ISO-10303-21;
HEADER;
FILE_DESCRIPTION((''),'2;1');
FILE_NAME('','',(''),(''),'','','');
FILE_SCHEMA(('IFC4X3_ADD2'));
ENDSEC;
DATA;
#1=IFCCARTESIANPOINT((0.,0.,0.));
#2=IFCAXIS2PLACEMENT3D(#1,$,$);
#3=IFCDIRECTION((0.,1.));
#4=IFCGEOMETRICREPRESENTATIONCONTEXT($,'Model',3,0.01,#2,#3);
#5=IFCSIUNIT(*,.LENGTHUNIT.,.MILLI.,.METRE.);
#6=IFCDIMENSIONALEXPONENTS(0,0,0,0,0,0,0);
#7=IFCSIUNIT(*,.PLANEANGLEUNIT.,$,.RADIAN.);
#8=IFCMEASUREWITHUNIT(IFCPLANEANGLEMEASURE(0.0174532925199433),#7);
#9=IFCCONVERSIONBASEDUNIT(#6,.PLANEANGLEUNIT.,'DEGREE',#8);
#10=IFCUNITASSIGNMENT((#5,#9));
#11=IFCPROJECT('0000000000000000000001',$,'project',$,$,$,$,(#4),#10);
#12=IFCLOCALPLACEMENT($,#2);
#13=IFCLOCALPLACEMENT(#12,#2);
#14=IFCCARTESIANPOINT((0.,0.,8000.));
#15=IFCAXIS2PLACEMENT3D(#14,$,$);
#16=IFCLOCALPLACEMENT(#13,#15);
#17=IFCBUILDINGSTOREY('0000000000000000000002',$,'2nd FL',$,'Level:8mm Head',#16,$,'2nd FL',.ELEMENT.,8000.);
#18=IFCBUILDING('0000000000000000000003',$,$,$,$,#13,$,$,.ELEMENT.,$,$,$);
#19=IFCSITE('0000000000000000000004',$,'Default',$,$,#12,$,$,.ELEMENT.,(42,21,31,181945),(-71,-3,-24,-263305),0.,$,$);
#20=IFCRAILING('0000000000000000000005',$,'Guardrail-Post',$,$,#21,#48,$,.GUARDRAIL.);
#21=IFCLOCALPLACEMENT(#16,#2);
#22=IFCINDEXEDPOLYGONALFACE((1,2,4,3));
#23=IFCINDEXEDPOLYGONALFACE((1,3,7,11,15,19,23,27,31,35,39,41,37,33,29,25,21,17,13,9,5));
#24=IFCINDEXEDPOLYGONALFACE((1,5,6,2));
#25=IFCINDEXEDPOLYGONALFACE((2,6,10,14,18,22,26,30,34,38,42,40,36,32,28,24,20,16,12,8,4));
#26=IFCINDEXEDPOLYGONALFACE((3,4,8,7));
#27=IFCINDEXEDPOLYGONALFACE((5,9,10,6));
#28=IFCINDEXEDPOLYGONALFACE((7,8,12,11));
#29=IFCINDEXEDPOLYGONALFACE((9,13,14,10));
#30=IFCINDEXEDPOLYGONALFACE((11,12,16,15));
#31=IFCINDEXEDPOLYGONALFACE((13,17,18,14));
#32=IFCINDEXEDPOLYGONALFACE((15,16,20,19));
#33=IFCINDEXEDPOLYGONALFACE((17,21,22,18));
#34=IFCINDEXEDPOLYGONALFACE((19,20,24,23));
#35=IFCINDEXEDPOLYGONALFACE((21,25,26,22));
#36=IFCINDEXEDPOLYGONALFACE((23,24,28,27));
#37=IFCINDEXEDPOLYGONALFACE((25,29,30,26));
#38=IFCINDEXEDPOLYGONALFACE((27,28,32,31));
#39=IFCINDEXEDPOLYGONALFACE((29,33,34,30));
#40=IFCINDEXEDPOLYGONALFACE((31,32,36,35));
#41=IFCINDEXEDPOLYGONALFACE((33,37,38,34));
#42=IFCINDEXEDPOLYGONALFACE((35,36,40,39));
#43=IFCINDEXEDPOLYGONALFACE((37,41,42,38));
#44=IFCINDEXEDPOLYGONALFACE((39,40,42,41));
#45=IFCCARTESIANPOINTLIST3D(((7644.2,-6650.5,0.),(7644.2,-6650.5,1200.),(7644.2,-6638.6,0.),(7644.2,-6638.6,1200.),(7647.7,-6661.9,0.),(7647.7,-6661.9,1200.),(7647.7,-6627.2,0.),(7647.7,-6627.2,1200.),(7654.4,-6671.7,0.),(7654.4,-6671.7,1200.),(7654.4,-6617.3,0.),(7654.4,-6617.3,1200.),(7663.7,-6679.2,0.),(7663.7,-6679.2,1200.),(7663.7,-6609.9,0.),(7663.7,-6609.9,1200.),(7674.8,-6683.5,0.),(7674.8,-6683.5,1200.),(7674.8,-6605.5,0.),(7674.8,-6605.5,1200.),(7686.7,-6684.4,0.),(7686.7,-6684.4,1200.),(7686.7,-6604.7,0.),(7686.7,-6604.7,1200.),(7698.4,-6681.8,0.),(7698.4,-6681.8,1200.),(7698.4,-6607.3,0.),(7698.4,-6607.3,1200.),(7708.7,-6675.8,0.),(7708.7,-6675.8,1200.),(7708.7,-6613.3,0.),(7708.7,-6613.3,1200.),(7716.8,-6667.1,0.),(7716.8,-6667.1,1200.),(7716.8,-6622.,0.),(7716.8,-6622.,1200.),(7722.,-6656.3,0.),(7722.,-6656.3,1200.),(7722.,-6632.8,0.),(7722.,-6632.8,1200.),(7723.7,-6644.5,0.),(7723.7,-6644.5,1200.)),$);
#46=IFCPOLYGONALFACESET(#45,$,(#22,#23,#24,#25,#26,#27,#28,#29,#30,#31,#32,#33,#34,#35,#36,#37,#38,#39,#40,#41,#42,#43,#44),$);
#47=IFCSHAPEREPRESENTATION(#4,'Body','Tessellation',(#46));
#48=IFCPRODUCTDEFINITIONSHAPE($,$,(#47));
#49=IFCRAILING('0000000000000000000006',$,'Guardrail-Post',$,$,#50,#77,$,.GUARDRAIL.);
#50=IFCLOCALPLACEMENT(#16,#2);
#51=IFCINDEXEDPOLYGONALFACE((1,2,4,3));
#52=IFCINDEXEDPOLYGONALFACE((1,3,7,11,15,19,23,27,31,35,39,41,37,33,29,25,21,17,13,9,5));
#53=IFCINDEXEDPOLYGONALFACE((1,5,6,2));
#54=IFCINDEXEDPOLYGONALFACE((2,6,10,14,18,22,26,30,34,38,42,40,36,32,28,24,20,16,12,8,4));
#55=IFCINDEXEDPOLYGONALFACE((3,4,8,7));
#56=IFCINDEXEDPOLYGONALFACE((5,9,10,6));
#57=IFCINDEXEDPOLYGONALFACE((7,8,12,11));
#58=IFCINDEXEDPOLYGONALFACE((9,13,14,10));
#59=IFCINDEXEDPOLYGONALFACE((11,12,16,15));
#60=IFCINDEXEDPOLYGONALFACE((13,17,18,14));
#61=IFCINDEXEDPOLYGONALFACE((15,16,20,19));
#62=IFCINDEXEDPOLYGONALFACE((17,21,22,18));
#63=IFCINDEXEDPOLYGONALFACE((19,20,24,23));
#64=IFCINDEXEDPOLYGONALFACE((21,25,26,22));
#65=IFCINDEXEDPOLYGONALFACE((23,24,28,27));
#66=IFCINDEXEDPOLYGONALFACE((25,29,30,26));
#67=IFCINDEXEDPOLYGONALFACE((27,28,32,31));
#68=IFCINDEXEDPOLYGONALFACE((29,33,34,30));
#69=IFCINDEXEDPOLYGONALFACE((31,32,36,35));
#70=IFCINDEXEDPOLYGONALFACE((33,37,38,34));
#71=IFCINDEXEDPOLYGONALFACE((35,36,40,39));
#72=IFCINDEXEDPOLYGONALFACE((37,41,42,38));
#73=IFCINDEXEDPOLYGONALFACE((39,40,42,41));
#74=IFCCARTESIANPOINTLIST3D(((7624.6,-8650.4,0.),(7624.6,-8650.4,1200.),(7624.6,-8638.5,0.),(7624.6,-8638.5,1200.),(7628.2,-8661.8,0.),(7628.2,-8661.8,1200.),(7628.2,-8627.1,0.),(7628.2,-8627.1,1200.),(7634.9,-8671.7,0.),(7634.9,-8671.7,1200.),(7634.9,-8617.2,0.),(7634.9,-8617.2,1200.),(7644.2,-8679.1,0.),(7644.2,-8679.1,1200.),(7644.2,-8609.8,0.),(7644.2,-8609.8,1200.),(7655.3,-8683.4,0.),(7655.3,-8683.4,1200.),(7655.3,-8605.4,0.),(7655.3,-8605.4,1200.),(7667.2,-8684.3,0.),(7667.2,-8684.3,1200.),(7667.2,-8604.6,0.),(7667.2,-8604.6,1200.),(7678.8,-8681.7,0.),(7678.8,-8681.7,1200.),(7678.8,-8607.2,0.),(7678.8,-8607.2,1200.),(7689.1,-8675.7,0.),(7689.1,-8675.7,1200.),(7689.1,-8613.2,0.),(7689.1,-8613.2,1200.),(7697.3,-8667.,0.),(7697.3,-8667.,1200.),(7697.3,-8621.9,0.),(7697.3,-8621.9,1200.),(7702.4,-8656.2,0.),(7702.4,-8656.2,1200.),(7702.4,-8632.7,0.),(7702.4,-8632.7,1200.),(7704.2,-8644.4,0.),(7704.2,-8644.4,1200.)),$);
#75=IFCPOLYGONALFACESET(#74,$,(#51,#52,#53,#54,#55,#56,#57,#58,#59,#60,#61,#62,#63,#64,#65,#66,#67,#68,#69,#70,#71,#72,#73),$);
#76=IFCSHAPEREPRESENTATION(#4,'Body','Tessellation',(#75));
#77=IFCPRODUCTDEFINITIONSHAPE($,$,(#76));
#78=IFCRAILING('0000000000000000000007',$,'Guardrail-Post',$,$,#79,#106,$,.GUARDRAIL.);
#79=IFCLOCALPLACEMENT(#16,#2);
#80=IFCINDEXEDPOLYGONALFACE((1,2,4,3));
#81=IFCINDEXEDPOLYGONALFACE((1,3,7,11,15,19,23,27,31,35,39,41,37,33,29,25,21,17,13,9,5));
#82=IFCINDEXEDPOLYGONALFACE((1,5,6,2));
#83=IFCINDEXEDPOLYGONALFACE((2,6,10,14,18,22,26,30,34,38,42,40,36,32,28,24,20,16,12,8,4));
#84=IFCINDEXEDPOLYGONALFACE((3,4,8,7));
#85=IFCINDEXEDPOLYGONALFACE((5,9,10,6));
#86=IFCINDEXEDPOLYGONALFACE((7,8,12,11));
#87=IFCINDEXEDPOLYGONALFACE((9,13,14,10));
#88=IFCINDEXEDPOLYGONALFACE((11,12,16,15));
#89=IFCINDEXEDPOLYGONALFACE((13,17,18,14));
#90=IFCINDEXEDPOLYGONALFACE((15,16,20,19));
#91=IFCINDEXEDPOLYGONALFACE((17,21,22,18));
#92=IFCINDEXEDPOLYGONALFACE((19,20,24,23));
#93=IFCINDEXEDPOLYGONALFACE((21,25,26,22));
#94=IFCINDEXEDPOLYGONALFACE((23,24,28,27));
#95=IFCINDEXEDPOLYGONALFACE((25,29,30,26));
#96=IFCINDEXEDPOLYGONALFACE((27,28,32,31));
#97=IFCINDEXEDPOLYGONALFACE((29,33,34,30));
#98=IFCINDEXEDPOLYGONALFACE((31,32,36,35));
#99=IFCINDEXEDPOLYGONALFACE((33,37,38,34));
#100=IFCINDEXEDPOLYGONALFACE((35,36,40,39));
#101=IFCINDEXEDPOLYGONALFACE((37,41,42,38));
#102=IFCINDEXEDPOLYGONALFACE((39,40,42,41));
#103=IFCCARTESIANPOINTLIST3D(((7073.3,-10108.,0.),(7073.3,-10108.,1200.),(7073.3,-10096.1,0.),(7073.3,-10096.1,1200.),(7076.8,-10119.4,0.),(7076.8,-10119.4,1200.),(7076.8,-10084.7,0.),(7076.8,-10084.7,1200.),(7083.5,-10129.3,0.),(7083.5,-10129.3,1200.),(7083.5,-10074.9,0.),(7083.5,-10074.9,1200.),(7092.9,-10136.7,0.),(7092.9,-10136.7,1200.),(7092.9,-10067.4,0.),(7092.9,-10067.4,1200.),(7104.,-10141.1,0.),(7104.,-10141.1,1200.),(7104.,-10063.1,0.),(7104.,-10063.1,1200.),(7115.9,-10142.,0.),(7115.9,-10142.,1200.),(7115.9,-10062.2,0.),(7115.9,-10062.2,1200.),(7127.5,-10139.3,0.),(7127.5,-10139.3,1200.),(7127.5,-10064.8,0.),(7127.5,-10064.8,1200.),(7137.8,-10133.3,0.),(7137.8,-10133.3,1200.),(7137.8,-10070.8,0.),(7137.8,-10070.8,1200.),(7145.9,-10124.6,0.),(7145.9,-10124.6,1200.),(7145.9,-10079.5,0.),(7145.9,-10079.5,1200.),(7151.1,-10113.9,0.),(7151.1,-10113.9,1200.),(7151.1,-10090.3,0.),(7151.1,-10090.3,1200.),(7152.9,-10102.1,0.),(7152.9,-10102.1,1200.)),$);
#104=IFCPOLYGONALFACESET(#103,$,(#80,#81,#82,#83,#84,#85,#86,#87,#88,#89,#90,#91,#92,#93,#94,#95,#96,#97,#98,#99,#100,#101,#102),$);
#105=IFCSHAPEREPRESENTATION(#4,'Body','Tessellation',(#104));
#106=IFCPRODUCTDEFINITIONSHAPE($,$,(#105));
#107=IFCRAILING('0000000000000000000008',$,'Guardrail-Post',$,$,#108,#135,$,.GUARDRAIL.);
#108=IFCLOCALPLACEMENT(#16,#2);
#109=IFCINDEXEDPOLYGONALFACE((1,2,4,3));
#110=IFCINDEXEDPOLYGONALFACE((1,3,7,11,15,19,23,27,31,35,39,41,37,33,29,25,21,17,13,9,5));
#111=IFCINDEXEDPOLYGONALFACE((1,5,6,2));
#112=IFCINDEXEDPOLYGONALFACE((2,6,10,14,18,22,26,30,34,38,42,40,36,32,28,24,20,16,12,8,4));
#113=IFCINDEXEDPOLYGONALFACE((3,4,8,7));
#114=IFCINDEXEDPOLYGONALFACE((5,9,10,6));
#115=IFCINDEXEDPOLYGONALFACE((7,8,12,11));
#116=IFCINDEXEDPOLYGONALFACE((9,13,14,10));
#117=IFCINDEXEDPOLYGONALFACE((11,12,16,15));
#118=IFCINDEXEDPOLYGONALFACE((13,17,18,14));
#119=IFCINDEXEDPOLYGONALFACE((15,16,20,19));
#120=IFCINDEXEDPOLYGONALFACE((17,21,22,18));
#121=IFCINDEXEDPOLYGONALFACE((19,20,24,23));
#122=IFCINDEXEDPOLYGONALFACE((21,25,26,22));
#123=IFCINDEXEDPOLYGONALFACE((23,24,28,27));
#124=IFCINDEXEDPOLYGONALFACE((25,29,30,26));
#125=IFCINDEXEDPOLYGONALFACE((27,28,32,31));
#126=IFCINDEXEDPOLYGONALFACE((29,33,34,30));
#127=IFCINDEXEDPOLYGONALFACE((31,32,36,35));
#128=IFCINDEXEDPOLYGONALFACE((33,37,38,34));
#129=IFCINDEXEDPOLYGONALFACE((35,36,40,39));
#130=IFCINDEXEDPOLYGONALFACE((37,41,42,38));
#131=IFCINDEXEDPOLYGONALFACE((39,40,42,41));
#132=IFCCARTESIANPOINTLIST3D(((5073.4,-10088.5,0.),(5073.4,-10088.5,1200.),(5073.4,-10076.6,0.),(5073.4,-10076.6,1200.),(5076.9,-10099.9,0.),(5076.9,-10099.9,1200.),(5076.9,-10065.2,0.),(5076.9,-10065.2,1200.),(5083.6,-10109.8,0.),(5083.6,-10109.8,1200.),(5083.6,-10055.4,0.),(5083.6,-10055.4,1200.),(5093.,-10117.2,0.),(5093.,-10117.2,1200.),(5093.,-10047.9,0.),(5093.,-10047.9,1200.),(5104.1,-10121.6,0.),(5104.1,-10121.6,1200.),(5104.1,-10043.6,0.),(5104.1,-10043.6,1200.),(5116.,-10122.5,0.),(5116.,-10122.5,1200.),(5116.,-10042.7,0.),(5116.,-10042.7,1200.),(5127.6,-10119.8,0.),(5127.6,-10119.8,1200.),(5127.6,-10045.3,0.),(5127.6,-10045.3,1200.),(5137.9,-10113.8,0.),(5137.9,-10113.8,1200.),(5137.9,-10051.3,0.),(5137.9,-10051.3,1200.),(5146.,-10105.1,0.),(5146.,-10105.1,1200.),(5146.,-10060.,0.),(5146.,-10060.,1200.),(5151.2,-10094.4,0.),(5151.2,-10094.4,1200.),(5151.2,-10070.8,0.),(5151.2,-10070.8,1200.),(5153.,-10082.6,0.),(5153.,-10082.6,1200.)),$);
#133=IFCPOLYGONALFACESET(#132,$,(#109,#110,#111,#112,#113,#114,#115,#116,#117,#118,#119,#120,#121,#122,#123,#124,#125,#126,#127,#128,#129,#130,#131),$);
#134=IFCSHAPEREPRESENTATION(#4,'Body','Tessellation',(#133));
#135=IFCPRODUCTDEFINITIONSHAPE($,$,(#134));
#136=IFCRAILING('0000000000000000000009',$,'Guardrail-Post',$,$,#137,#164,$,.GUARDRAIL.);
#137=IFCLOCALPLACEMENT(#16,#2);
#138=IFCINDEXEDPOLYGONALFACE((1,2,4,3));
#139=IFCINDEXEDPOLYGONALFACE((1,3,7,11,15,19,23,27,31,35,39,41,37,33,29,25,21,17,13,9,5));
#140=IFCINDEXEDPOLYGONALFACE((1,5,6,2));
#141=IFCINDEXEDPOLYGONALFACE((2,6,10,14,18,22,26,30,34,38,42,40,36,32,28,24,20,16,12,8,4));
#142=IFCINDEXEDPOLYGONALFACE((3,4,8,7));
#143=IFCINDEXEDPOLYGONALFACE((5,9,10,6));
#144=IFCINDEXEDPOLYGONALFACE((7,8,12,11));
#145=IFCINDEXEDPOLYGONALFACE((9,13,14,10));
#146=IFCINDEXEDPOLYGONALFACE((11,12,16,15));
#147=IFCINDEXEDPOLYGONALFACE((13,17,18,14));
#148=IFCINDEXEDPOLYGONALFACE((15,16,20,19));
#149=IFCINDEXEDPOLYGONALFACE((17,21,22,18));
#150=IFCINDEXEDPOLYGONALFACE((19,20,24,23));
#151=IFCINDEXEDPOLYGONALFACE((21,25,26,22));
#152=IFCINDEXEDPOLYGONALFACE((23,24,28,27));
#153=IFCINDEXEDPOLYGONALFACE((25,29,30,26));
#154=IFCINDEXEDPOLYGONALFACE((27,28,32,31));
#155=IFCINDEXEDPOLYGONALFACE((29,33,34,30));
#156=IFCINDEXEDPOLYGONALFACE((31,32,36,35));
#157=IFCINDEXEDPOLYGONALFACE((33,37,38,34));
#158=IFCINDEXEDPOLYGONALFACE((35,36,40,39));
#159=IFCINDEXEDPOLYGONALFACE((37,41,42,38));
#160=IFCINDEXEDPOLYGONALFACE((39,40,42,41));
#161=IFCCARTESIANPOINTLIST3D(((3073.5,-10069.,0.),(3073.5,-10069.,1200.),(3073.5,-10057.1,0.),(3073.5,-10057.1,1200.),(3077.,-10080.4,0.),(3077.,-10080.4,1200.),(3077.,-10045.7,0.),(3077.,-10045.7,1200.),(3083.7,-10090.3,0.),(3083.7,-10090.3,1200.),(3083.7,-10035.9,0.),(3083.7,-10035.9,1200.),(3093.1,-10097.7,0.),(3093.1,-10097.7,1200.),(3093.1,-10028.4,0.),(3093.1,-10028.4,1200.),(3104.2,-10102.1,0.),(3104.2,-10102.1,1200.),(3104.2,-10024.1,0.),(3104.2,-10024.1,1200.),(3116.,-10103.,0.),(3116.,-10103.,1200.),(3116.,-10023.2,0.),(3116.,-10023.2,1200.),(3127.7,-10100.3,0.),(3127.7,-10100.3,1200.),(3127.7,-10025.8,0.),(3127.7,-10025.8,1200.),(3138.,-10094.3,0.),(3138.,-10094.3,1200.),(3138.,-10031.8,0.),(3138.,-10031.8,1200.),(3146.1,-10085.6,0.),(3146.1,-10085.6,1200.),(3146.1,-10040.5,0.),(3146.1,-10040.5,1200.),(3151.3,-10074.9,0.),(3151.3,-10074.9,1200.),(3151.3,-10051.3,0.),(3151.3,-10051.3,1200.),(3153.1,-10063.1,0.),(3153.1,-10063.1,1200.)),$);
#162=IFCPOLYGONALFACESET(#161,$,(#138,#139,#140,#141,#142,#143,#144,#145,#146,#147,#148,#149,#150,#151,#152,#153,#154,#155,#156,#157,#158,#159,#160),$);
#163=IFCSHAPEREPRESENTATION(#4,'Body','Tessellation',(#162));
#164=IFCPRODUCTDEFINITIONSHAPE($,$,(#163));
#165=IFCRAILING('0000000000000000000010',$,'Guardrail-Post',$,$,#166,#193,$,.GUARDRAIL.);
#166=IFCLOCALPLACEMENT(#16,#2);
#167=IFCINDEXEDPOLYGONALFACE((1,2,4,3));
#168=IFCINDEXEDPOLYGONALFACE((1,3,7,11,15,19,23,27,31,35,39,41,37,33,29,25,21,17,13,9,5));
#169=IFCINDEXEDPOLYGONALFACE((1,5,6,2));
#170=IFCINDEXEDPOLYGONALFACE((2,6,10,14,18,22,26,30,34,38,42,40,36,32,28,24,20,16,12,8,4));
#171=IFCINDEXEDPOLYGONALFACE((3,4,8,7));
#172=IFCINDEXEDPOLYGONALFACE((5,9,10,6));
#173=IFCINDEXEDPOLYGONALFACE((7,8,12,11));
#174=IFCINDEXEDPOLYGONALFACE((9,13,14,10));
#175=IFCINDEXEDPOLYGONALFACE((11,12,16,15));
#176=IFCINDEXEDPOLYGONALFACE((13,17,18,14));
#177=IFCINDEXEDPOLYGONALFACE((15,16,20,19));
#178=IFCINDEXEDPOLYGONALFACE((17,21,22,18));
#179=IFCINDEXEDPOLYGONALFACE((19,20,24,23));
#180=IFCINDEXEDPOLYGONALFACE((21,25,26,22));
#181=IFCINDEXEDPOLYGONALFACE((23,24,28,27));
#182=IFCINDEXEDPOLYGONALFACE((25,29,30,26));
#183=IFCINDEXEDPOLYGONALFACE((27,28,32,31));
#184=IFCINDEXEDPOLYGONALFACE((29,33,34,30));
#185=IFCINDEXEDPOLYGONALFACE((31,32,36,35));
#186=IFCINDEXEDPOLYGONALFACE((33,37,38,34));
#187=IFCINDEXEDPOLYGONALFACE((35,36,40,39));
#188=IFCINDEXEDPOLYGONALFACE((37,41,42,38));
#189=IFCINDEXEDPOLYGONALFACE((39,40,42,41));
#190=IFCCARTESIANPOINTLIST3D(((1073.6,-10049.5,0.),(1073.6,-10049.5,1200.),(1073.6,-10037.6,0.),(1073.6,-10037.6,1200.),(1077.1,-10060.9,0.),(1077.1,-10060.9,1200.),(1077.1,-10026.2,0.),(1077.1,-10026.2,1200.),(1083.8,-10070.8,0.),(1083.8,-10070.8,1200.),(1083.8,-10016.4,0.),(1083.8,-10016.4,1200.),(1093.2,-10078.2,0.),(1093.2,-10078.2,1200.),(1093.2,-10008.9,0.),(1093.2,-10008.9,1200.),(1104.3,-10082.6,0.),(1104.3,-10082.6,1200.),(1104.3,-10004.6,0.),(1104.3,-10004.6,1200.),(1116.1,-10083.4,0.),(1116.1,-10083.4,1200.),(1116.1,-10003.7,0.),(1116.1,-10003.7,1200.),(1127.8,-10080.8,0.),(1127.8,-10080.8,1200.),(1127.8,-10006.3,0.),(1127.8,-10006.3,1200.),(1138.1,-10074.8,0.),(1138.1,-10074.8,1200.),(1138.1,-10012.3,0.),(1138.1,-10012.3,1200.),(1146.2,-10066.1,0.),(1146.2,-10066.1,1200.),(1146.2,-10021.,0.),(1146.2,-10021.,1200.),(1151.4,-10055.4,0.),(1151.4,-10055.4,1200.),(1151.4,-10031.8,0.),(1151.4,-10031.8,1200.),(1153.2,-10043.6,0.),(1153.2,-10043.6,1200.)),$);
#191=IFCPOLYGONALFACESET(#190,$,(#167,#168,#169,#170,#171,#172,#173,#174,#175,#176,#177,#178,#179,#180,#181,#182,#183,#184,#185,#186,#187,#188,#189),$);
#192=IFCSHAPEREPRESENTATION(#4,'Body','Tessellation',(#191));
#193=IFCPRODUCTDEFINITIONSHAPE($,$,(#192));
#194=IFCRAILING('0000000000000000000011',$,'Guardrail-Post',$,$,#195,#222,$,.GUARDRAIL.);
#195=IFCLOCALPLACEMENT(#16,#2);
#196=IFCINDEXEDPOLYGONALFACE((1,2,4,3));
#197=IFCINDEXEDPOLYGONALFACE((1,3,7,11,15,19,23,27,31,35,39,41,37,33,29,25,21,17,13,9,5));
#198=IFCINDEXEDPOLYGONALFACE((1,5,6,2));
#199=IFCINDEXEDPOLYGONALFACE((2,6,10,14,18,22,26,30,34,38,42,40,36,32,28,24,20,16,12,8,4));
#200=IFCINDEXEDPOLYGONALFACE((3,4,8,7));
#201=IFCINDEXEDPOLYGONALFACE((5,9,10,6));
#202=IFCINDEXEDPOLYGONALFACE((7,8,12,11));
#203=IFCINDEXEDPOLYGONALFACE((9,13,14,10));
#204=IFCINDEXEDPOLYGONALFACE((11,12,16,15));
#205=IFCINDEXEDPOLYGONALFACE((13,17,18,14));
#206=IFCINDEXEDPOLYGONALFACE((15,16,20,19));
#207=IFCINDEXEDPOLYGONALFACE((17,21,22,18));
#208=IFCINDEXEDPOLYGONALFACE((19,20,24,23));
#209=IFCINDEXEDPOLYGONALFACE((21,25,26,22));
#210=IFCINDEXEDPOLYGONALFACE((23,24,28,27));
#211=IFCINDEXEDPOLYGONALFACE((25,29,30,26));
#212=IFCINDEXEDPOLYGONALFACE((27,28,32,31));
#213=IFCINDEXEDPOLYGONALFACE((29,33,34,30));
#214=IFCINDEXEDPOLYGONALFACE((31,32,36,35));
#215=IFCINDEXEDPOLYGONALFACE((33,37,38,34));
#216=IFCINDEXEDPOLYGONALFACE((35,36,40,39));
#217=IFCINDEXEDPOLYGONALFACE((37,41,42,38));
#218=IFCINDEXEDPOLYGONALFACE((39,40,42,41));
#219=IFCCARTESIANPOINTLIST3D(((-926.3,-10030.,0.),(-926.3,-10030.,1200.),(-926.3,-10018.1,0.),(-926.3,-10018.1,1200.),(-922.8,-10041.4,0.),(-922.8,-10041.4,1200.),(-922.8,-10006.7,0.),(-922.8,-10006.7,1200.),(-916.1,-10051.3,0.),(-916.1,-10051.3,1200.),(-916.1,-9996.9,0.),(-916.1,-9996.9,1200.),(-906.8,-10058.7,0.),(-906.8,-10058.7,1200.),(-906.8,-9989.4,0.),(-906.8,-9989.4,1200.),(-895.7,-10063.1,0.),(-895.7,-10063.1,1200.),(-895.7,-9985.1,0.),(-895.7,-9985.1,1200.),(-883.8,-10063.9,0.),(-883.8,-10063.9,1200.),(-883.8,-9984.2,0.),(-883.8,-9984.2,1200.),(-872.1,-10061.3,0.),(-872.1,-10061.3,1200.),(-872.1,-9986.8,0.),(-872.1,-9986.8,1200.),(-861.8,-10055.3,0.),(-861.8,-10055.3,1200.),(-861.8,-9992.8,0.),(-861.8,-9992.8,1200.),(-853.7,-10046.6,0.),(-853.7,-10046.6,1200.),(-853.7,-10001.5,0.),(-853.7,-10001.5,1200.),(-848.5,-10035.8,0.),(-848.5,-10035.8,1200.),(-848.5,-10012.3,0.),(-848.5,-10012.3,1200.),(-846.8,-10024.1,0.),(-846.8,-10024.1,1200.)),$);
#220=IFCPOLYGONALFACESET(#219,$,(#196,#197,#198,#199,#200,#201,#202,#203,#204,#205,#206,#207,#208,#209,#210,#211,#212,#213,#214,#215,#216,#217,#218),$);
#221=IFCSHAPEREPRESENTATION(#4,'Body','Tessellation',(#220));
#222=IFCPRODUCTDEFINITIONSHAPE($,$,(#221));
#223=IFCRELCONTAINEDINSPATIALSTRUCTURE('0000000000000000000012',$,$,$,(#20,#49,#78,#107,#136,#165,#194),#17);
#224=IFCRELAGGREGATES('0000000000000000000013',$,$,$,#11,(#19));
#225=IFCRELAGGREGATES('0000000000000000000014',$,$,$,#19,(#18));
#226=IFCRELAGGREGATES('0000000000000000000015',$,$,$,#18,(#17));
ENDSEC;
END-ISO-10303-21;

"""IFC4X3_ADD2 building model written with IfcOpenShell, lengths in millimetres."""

from ifc_helpers import new_model, entity, si_unit, converted_unit, direction, frame, origin, origin_with_axes, origin_2d, place, context, project, spatial, circle, extrude, element, save


model = new_model("IFC4X3_ADD2")

# Units and contexts
model_context = context("Model", 3, precision=0.01, world=origin(), true_north=direction((0.0, 1.0)))
ifc_project = project(units=[si_unit("LENGTHUNIT", "METRE", prefix="MILLI"), converted_unit("PLANEANGLEUNIT", "DEGREE", entity("IfcPlaneAngleMeasure", 0.0174532925199433), si_unit("PLANEANGLEUNIT", "RADIAN"), dimensions=[0, 0, 0, 0, 0, 0, 0])], contexts=[model_context])

# Site, building, storey
site_placement = place(None, origin())
site = spatial("IfcSite", under=ifc_project, at=site_placement, Name="Default", CompositionType="ELEMENT", RefLatitude=(42, 21, 31, 181945), RefLongitude=(-71, -3, -24, -263305), RefElevation=0.0)
building_placement = place(site_placement, origin())
building = spatial("IfcBuilding", under=site, at=building_placement, CompositionType="ELEMENT")
storey_placement = place(building_placement, frame((0.0, 0.0, 8000.0)))
storey = spatial("IfcBuildingStorey", under=building, at=storey_placement, Name="2nd FL", ObjectType="Level:8mm Head", LongName="2nd FL", CompositionType="ELEMENT", Elevation=8000.0)

# Railings
for number, where, z_axis, x_axis, name in (
    (1, (7683.7, -6644.5, 8000.0), (0.0, 0.0, 1.0), (1.0, 0.0, 0.0), "Guardrail-Post"),
    (2, (7664.2, -8644.4, 8000.0), (0.0, 0.0, 1.0), (1.0, 0.0, 0.0), "Guardrail-Post"),
    (3, (7112.9, -10102.1, 8000.0), (0.0, 0.0, 1.0), (1.0, 0.0, 0.0), "Guardrail-Post"),
    (4, (5113.0, -10082.6, 8000.0), (0.0, 0.0, 1.0), (1.0, 0.0, 0.0), "Guardrail-Post"),
    (5, (3113.1, -10063.1, 8000.0), (0.0, 0.0, 1.0), (1.0, 0.0, 0.0), "Guardrail-Post"),
    (6, (1113.2, -10043.6, 8000.0), (0.0, 0.0, 1.0), (1.0, 0.0, 0.0), "Guardrail-Post"),
    (7, (-886.8, -10024.1, 8000.0), (0.0, 0.0, 1.0), (1.0, 0.0, 0.0), "Guardrail-Post"),
):
    element("IfcRailing", number, at=place(None, frame(where, z_axis=z_axis, x_axis=x_axis)), inside=storey, Name=name, PredefinedType="GUARDRAIL", context=model_context, shape_type="SweptSolid", body=[
        extrude(circle(Radius=40.0, at=origin_2d()), origin_with_axes(), (0.0, 0.0, 1.0), 1200.0),
    ])

save(model, "model.ifc")
